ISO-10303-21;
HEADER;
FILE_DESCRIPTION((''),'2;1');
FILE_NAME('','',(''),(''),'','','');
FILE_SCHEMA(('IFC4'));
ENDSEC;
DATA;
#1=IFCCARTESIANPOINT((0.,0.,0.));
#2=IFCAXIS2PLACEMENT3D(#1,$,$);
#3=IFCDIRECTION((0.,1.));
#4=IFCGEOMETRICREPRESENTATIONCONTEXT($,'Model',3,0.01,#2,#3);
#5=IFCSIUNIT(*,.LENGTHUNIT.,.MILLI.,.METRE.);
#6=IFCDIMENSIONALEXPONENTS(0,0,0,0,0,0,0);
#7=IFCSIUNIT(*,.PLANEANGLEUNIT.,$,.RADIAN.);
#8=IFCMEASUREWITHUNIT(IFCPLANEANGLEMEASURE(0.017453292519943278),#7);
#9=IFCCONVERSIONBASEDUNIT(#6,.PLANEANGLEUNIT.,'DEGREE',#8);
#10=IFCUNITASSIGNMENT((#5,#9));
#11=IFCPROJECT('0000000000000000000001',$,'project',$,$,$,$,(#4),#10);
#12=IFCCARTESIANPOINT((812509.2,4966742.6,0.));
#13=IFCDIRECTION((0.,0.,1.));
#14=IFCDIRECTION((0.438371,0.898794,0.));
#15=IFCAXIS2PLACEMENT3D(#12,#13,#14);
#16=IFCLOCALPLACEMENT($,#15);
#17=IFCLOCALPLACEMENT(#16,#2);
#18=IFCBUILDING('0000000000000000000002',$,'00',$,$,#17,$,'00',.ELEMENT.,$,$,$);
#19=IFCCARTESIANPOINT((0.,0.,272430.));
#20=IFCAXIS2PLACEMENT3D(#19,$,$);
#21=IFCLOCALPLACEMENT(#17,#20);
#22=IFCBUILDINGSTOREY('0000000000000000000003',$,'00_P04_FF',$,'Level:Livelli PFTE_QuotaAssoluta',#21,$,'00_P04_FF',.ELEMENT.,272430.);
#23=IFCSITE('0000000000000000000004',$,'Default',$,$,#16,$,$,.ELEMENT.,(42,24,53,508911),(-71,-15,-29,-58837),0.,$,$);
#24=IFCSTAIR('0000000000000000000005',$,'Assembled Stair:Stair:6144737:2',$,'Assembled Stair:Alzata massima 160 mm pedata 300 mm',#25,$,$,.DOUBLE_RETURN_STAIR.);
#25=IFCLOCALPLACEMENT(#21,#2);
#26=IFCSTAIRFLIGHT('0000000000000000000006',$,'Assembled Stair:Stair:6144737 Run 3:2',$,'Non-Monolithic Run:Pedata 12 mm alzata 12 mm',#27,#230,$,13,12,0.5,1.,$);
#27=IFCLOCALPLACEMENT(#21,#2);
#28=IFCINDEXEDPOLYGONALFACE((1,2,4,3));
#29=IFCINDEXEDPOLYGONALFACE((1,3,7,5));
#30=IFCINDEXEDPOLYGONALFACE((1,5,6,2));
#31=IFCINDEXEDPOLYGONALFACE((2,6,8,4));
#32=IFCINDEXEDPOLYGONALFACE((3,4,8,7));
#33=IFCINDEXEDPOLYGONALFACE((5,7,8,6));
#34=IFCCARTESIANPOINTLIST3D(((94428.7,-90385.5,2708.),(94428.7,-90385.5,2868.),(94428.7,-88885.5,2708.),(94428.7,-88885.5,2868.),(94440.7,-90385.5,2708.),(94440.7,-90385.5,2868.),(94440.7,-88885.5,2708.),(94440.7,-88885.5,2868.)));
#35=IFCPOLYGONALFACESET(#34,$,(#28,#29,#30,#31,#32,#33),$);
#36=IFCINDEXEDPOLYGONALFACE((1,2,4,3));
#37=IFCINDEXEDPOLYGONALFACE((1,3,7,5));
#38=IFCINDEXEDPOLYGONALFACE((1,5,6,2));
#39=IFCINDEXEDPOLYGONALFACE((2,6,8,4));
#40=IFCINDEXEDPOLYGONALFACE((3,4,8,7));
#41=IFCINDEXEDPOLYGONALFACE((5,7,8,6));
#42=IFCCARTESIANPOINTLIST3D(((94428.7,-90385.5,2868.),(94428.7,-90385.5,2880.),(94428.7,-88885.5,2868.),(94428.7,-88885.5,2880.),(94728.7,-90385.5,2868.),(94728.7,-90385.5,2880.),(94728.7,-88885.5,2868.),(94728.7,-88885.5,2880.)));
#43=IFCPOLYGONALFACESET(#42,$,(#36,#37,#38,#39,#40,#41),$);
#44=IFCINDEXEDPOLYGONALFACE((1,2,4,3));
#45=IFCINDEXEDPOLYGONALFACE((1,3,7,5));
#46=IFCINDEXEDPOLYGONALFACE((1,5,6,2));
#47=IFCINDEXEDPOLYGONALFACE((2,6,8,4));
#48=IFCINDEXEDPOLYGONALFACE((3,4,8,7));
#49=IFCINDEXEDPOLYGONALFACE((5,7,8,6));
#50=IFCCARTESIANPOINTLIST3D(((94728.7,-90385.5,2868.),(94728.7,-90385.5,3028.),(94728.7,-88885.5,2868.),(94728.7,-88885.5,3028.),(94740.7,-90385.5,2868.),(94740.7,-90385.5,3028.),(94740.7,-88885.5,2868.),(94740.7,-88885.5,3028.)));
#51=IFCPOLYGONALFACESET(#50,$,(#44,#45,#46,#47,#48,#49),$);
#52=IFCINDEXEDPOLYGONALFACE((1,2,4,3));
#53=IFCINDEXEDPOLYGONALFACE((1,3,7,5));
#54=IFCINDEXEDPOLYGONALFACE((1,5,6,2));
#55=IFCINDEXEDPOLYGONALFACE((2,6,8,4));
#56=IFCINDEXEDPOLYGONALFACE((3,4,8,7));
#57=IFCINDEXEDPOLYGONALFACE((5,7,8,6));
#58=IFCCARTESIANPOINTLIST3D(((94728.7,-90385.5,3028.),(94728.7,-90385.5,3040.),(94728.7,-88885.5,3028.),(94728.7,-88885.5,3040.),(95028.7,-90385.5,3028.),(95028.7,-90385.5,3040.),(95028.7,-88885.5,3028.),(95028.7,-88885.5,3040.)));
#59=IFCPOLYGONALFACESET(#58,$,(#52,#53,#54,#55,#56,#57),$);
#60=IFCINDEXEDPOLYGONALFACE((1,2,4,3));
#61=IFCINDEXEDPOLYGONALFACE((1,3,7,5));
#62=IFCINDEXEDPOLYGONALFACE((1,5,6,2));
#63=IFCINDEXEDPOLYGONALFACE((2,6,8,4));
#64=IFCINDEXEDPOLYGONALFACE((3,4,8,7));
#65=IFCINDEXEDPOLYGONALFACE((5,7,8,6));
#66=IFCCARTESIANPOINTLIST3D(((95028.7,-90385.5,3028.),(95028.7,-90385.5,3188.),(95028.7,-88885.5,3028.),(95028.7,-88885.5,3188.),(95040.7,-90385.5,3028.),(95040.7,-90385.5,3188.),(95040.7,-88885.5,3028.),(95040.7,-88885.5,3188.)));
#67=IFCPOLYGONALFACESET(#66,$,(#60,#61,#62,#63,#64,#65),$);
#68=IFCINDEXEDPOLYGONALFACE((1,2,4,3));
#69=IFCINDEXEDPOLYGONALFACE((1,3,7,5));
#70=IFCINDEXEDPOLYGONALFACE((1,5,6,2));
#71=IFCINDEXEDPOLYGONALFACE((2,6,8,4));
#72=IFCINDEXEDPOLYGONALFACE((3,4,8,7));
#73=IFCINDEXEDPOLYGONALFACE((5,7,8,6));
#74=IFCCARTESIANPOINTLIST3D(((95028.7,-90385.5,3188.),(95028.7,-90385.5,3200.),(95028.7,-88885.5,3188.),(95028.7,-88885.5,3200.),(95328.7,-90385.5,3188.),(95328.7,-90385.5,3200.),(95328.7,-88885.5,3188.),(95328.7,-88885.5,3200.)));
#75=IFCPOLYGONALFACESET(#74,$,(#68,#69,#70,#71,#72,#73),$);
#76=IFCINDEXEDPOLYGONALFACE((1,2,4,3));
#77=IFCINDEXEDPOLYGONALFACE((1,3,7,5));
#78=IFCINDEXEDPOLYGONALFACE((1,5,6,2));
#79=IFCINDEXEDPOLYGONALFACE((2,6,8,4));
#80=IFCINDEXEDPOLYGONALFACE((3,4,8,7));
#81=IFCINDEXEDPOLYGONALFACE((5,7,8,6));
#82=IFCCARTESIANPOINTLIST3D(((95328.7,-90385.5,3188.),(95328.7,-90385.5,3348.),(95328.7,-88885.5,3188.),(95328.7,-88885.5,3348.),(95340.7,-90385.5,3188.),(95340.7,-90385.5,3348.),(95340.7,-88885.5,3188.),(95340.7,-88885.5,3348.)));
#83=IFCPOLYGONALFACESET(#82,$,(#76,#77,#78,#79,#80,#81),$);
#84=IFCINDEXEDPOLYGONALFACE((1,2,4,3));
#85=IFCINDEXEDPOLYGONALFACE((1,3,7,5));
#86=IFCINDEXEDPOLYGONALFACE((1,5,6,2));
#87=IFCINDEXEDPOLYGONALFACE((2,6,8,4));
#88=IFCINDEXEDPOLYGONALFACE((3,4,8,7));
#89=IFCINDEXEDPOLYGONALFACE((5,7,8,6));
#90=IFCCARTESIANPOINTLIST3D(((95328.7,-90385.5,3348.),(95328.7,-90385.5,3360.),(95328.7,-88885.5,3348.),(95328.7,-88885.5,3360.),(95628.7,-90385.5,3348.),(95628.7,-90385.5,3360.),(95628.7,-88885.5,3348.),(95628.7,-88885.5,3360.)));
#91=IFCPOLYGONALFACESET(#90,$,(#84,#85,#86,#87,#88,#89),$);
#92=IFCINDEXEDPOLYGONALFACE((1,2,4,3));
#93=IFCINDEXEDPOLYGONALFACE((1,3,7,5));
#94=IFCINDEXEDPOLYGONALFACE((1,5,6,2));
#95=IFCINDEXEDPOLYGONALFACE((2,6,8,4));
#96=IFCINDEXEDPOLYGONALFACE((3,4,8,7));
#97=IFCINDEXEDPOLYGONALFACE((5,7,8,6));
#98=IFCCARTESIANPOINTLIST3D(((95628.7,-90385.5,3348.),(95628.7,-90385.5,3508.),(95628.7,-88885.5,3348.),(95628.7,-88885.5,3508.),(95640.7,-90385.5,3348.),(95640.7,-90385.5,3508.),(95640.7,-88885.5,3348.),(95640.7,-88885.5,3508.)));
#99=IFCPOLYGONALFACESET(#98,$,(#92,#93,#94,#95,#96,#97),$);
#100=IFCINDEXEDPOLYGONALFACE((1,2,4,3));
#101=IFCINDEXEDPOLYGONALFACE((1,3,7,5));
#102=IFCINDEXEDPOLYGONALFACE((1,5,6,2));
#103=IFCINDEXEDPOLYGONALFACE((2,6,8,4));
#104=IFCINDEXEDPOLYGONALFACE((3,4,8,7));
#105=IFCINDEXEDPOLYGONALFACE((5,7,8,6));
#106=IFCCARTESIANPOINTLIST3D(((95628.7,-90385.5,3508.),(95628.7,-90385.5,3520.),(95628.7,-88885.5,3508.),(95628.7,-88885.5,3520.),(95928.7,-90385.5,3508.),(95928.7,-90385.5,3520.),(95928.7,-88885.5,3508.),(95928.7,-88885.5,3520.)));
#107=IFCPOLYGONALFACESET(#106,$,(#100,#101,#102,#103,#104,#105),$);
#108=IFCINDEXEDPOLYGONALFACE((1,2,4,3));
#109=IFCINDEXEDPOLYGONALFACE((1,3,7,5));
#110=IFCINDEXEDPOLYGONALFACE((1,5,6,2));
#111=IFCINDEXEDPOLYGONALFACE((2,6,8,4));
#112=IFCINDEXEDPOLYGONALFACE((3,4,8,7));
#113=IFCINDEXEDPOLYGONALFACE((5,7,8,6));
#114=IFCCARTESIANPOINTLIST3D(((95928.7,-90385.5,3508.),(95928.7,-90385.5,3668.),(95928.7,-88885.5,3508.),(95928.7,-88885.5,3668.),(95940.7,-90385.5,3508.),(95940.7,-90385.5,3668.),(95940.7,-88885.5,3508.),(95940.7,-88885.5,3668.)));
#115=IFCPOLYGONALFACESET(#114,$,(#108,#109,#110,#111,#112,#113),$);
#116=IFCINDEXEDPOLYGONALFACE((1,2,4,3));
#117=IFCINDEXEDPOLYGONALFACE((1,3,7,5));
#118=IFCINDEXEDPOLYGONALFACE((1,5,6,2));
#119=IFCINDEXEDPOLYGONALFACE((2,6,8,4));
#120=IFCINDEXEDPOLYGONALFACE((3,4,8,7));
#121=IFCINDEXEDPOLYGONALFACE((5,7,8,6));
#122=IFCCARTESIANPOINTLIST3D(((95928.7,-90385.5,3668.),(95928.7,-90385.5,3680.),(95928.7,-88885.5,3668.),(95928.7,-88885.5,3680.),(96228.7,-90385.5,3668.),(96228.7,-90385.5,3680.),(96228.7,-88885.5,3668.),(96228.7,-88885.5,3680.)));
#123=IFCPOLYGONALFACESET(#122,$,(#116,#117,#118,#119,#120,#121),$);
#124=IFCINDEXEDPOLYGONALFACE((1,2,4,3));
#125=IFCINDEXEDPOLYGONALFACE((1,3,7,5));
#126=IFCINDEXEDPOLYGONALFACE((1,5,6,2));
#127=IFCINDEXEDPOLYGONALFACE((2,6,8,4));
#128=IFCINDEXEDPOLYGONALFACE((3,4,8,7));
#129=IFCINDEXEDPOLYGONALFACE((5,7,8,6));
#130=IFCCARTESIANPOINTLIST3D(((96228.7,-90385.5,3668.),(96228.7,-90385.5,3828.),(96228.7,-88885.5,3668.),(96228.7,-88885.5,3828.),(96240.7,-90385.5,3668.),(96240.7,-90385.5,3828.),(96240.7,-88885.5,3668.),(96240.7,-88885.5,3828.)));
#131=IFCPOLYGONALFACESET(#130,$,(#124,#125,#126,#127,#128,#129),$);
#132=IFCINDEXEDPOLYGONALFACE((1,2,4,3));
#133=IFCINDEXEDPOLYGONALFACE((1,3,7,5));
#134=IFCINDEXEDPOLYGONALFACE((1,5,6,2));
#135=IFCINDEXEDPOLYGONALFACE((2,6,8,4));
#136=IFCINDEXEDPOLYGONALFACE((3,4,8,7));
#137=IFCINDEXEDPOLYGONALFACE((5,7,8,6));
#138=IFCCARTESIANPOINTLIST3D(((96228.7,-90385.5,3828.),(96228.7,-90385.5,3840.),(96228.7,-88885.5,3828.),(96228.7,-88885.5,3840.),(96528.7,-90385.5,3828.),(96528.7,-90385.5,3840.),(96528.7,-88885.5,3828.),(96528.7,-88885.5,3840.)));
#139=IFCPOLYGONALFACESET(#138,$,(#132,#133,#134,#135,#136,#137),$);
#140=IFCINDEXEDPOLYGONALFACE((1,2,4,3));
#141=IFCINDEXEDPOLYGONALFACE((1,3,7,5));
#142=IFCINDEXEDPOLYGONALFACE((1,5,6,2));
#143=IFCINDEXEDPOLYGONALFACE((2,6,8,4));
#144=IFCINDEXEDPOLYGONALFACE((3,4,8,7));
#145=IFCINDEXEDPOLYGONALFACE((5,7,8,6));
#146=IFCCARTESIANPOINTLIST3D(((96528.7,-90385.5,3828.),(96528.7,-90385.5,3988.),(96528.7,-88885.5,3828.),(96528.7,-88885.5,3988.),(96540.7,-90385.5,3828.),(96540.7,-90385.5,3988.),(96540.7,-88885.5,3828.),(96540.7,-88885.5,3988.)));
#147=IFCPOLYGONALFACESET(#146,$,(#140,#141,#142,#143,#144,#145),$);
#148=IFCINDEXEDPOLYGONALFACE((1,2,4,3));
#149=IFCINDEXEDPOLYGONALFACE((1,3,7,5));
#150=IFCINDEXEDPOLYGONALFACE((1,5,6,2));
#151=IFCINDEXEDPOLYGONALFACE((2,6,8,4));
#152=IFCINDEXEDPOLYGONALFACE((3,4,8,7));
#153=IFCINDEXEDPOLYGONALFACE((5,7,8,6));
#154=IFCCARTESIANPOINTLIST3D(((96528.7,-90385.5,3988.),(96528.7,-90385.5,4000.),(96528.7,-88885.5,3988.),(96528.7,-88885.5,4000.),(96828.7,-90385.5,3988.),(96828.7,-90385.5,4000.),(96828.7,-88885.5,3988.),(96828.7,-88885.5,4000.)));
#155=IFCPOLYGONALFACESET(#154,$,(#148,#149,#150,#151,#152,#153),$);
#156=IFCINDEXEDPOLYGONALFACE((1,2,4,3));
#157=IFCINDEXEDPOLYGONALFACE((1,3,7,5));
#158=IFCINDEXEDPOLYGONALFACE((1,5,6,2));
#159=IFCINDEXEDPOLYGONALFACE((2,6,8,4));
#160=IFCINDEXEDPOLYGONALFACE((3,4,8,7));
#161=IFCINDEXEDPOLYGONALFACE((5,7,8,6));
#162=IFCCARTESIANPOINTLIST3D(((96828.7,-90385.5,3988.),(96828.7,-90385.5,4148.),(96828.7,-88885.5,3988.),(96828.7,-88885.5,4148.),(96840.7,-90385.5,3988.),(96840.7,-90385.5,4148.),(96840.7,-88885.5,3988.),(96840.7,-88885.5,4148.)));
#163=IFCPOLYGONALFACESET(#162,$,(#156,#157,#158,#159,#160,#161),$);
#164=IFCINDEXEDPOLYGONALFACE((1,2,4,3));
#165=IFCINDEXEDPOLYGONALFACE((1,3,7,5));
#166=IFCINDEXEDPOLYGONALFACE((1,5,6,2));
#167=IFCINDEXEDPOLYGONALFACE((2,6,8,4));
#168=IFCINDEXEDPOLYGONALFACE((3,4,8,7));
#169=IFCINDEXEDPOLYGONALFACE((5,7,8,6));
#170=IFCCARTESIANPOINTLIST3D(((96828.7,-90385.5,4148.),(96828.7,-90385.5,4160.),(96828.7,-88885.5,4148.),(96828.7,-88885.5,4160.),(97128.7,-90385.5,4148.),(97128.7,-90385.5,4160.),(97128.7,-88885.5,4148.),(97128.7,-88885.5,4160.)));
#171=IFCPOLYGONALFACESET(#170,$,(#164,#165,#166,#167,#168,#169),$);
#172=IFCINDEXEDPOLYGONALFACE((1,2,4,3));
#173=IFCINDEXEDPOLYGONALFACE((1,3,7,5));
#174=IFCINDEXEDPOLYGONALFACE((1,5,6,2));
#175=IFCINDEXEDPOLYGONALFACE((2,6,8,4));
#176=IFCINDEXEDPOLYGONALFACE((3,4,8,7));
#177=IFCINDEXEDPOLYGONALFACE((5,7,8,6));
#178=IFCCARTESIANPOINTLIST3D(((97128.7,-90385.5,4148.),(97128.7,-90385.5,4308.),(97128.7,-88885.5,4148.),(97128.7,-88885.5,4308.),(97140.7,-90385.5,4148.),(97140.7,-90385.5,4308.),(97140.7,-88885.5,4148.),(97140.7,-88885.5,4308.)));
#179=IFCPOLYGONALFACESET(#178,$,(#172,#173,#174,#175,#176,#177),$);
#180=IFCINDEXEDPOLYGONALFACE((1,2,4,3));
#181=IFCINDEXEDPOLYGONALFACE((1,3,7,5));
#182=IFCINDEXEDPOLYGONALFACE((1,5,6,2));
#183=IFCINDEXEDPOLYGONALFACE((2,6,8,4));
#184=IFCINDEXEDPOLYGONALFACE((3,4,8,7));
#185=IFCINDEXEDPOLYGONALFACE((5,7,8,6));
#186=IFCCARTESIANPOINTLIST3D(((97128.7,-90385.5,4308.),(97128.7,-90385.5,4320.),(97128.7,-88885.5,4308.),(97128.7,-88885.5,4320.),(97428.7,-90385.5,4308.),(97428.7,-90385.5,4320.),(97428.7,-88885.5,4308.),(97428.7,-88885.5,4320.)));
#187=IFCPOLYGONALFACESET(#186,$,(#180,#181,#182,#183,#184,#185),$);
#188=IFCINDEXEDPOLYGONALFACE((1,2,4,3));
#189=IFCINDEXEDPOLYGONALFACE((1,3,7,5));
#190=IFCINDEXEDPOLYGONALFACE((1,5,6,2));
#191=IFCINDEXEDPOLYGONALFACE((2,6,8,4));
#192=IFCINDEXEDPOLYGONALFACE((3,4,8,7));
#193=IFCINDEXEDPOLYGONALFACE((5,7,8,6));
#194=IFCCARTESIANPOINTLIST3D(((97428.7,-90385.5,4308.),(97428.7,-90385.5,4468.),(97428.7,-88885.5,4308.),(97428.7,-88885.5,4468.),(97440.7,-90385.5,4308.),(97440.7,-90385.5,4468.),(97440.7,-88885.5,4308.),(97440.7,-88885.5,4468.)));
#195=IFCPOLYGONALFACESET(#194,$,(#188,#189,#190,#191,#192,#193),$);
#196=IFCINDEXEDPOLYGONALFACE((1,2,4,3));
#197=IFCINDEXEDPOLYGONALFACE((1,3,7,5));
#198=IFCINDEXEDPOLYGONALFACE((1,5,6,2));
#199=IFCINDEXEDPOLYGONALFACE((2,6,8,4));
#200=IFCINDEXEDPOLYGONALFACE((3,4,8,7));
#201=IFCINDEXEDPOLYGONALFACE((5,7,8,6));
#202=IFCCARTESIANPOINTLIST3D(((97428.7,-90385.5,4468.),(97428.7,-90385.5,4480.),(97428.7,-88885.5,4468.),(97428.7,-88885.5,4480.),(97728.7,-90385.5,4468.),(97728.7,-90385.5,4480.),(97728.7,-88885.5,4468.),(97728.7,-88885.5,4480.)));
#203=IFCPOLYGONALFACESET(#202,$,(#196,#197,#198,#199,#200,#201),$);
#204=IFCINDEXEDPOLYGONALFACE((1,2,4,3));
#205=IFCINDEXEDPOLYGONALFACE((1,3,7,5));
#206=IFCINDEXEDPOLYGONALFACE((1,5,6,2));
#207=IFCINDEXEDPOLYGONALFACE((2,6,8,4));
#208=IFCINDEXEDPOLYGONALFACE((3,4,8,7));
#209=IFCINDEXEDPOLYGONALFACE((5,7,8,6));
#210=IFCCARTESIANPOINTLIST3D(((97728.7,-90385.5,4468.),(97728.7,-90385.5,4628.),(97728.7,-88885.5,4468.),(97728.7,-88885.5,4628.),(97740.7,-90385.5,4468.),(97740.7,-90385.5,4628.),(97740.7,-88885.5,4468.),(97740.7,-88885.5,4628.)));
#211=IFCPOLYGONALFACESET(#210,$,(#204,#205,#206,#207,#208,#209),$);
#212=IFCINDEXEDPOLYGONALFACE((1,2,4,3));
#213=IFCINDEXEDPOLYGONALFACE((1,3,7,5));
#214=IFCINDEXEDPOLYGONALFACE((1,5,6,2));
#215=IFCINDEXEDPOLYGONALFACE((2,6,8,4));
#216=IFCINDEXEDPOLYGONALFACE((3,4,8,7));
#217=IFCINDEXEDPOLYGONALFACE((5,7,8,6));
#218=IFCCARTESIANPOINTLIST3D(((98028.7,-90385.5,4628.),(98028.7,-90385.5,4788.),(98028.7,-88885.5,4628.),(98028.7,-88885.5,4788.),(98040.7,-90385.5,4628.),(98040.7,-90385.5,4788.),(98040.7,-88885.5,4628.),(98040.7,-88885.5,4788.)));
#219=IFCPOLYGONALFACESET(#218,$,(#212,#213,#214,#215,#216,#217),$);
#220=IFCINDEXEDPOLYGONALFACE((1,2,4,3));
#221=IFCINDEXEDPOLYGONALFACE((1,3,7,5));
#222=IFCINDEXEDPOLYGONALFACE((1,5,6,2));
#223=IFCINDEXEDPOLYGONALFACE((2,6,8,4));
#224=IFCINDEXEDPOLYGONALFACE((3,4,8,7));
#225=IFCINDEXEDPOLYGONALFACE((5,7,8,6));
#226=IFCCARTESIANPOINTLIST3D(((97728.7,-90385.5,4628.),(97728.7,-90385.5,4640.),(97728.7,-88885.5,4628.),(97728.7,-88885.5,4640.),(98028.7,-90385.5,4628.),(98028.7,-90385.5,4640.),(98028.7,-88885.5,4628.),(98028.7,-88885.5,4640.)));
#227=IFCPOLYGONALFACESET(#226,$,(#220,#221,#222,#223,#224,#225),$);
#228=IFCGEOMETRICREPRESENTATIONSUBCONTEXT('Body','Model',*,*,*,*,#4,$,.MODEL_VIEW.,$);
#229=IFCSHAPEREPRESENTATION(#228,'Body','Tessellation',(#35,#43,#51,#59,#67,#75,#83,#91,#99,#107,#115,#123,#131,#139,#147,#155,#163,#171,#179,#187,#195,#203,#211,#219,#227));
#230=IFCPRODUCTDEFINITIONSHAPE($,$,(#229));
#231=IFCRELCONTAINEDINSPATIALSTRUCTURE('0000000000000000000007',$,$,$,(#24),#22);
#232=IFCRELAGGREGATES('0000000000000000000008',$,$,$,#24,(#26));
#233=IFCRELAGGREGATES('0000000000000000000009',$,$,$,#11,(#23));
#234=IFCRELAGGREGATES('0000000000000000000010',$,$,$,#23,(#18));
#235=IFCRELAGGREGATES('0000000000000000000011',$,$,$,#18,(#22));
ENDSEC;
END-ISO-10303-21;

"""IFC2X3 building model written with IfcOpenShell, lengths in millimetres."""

from ifc_helpers import new_model, entity, si_unit, converted_unit, direction, frame, origin, origin_2d_with_axis, place, context, subcontext, project, spatial, rectangle, extrude, element, aggregate, save


model = new_model("IFC2X3")

# Units and contexts
model_context = context("Model", 3, precision=0.01, world=origin(), true_north=direction((0.0, 1.0)))
body_context = subcontext(model_context, "Body", "Model", "MODEL_VIEW")
ifc_project = project(units=[si_unit("LENGTHUNIT", "METRE", prefix="MILLI"), converted_unit("PLANEANGLEUNIT", "DEGREE", entity("IfcPlaneAngleMeasure", 0.017453292519943278), si_unit("PLANEANGLEUNIT", "RADIAN"), dimensions=[0, 0, 0, 0, 0, 0, 0])], contexts=[model_context])

# Site, building, storey
site_placement = place(None, frame((812509.2, 4966742.6, 0.0), z_axis=(0.0, 0.0, 1.0), x_axis=(0.438371, 0.898794, 0.0)))
site = spatial("IfcSite", under=ifc_project, at=site_placement, Name="Default", CompositionType="ELEMENT", RefLatitude=(42, 24, 53, 508911), RefLongitude=(-71, -15, -29, -58837), RefElevation=0.0)
building_placement = place(site_placement, origin())
building = spatial("IfcBuilding", under=site, at=building_placement, Name="00", LongName="00", CompositionType="ELEMENT")
storey_placement = place(building_placement, frame((0.0, 0.0, 272430.0)))
storey = spatial("IfcBuildingStorey", under=building, at=storey_placement, Name="00_P04_FF", ObjectType="Level:Livelli PFTE_QuotaAssoluta", LongName="00_P04_FF", CompositionType="ELEMENT", Elevation=272430.0)

# Stair
stair_1_placement = place(storey_placement, origin())
stair_1 = element("IfcStair", 1, at=stair_1_placement, inside=storey, Name="Assembled Stair:Stair:6144737:2", ObjectType="Assembled Stair:Alzata massima 160 mm pedata 300 mm", ShapeType="DOUBLE_RETURN_STAIR")

# Stair flight
stair_flight_1_placement = place(stair_1_placement, origin())
stair_flight_1 = element("IfcStairFlight", 2, at=stair_flight_1_placement, Name="Assembled Stair:Stair:6144737 Run 3:2", ObjectType="Non-Monolithic Run:Pedata 12 mm alzata 12 mm", NumberOfRiser=13, NumberOfTreads=12, RiserHeight=0.5, TreadLength=1.0, context=body_context, shape_type="SweptSolid", body=[
    extrude(rectangle(XDim=1500.0, YDim=12.0, at=origin_2d_with_axis()), frame((94434.7, -89635.5, 2708.0), z_axis=(0.0, 0.0, 1.0), x_axis=(0.0, 1.0, 0.0)), (0.0, 0.0, 1.0), 160.0),
    extrude(rectangle(XDim=300.0, YDim=1500.0, at=origin_2d_with_axis()), frame((94578.7, -89635.5, 2868.0), z_axis=(0.0, 0.0, 1.0), x_axis=(-1.0, 0.0, 0.0)), (0.0, 0.0, 1.0), 12.0),
    extrude(rectangle(XDim=1500.0, YDim=12.0, at=origin_2d_with_axis()), frame((94734.7, -89635.5, 2868.0), z_axis=(0.0, 0.0, 1.0), x_axis=(0.0, 1.0, 0.0)), (0.0, 0.0, 1.0), 160.0),
    extrude(rectangle(XDim=300.0, YDim=1500.0, at=origin_2d_with_axis()), frame((94878.7, -89635.5, 3028.0), z_axis=(0.0, 0.0, 1.0), x_axis=(-1.0, 0.0, 0.0)), (0.0, 0.0, 1.0), 12.0),
    extrude(rectangle(XDim=1500.0, YDim=12.0, at=origin_2d_with_axis()), frame((95034.7, -89635.5, 3028.0), z_axis=(0.0, 0.0, 1.0), x_axis=(0.0, 1.0, 0.0)), (0.0, 0.0, 1.0), 160.0),
    extrude(rectangle(XDim=300.0, YDim=1500.0, at=origin_2d_with_axis()), frame((95178.7, -89635.5, 3188.0), z_axis=(0.0, 0.0, 1.0), x_axis=(-1.0, 0.0, 0.0)), (0.0, 0.0, 1.0), 12.0),
    extrude(rectangle(XDim=1500.0, YDim=12.0, at=origin_2d_with_axis()), frame((95334.7, -89635.5, 3188.0), z_axis=(0.0, 0.0, 1.0), x_axis=(0.0, 1.0, 0.0)), (0.0, 0.0, 1.0), 160.0),
    extrude(rectangle(XDim=300.0, YDim=1500.0, at=origin_2d_with_axis()), frame((95478.7, -89635.5, 3348.0), z_axis=(0.0, 0.0, 1.0), x_axis=(-1.0, 0.0, 0.0)), (0.0, 0.0, 1.0), 12.0),
    extrude(rectangle(XDim=1500.0, YDim=12.0, at=origin_2d_with_axis()), frame((95634.7, -89635.5, 3348.0), z_axis=(0.0, 0.0, 1.0), x_axis=(0.0, 1.0, 0.0)), (0.0, 0.0, 1.0), 160.0),
    extrude(rectangle(XDim=300.0, YDim=1500.0, at=origin_2d_with_axis()), frame((95778.7, -89635.5, 3508.0), z_axis=(0.0, 0.0, 1.0), x_axis=(-1.0, 0.0, 0.0)), (0.0, 0.0, 1.0), 12.0),
    extrude(rectangle(XDim=1500.0, YDim=12.0, at=origin_2d_with_axis()), frame((95934.7, -89635.5, 3508.0), z_axis=(0.0, 0.0, 1.0), x_axis=(0.0, 1.0, 0.0)), (0.0, 0.0, 1.0), 160.0),
    extrude(rectangle(XDim=300.0, YDim=1500.0, at=origin_2d_with_axis()), frame((96078.7, -89635.5, 3668.0), z_axis=(0.0, 0.0, 1.0), x_axis=(-1.0, 0.0, 0.0)), (0.0, 0.0, 1.0), 12.0),
    extrude(rectangle(XDim=1500.0, YDim=12.0, at=origin_2d_with_axis()), frame((96234.7, -89635.5, 3668.0), z_axis=(0.0, 0.0, 1.0), x_axis=(0.0, 1.0, 0.0)), (0.0, 0.0, 1.0), 160.0),
    extrude(rectangle(XDim=300.0, YDim=1500.0, at=origin_2d_with_axis()), frame((96378.7, -89635.5, 3828.0), z_axis=(0.0, 0.0, 1.0), x_axis=(-1.0, 0.0, 0.0)), (0.0, 0.0, 1.0), 12.0),
    extrude(rectangle(XDim=1500.0, YDim=12.0, at=origin_2d_with_axis()), frame((96534.7, -89635.5, 3828.0), z_axis=(0.0, 0.0, 1.0), x_axis=(0.0, 1.0, 0.0)), (0.0, 0.0, 1.0), 160.0),
    extrude(rectangle(XDim=300.0, YDim=1500.0, at=origin_2d_with_axis()), frame((96678.7, -89635.5, 3988.0), z_axis=(0.0, 0.0, 1.0), x_axis=(-1.0, 0.0, 0.0)), (0.0, 0.0, 1.0), 12.0),
    extrude(rectangle(XDim=1500.0, YDim=12.0, at=origin_2d_with_axis()), frame((96834.7, -89635.5, 3988.0), z_axis=(0.0, 0.0, 1.0), x_axis=(0.0, 1.0, 0.0)), (0.0, 0.0, 1.0), 160.0),
    extrude(rectangle(XDim=300.0, YDim=1500.0, at=origin_2d_with_axis()), frame((96978.7, -89635.5, 4148.0), z_axis=(0.0, 0.0, 1.0), x_axis=(-1.0, 0.0, 0.0)), (0.0, 0.0, 1.0), 12.0),
    extrude(rectangle(XDim=1500.0, YDim=12.0, at=origin_2d_with_axis()), frame((97134.7, -89635.5, 4148.0), z_axis=(0.0, 0.0, 1.0), x_axis=(0.0, 1.0, 0.0)), (0.0, 0.0, 1.0), 160.0),
    extrude(rectangle(XDim=300.0, YDim=1500.0, at=origin_2d_with_axis()), frame((97278.7, -89635.5, 4308.0), z_axis=(0.0, 0.0, 1.0), x_axis=(-1.0, 0.0, 0.0)), (0.0, 0.0, 1.0), 12.0),
    extrude(rectangle(XDim=1500.0, YDim=12.0, at=origin_2d_with_axis()), frame((97434.7, -89635.5, 4308.0), z_axis=(0.0, 0.0, 1.0), x_axis=(0.0, 1.0, 0.0)), (0.0, 0.0, 1.0), 160.0),
    extrude(rectangle(XDim=300.0, YDim=1500.0, at=origin_2d_with_axis()), frame((97578.7, -89635.5, 4468.0), z_axis=(0.0, 0.0, 1.0), x_axis=(-1.0, 0.0, 0.0)), (0.0, 0.0, 1.0), 12.0),
    extrude(rectangle(XDim=1500.0, YDim=12.0, at=origin_2d_with_axis()), frame((97734.7, -89635.5, 4468.0), z_axis=(0.0, 0.0, 1.0), x_axis=(0.0, 1.0, 0.0)), (0.0, 0.0, 1.0), 160.0),
    extrude(rectangle(XDim=1500.0, YDim=12.0, at=origin_2d_with_axis()), frame((98034.7, -89635.5, 4628.0), z_axis=(0.0, 0.0, 1.0), x_axis=(0.0, 1.0, 0.0)), (0.0, 0.0, 1.0), 160.0),
    extrude(rectangle(XDim=300.0, YDim=1500.0, at=origin_2d_with_axis()), frame((97878.7, -89635.5, 4628.0), z_axis=(0.0, 0.0, 1.0), x_axis=(-1.0, 0.0, 0.0)), (0.0, 0.0, 1.0), 12.0),
])
aggregate(stair_1, [stair_flight_1])

save(model, "model.ifc")
